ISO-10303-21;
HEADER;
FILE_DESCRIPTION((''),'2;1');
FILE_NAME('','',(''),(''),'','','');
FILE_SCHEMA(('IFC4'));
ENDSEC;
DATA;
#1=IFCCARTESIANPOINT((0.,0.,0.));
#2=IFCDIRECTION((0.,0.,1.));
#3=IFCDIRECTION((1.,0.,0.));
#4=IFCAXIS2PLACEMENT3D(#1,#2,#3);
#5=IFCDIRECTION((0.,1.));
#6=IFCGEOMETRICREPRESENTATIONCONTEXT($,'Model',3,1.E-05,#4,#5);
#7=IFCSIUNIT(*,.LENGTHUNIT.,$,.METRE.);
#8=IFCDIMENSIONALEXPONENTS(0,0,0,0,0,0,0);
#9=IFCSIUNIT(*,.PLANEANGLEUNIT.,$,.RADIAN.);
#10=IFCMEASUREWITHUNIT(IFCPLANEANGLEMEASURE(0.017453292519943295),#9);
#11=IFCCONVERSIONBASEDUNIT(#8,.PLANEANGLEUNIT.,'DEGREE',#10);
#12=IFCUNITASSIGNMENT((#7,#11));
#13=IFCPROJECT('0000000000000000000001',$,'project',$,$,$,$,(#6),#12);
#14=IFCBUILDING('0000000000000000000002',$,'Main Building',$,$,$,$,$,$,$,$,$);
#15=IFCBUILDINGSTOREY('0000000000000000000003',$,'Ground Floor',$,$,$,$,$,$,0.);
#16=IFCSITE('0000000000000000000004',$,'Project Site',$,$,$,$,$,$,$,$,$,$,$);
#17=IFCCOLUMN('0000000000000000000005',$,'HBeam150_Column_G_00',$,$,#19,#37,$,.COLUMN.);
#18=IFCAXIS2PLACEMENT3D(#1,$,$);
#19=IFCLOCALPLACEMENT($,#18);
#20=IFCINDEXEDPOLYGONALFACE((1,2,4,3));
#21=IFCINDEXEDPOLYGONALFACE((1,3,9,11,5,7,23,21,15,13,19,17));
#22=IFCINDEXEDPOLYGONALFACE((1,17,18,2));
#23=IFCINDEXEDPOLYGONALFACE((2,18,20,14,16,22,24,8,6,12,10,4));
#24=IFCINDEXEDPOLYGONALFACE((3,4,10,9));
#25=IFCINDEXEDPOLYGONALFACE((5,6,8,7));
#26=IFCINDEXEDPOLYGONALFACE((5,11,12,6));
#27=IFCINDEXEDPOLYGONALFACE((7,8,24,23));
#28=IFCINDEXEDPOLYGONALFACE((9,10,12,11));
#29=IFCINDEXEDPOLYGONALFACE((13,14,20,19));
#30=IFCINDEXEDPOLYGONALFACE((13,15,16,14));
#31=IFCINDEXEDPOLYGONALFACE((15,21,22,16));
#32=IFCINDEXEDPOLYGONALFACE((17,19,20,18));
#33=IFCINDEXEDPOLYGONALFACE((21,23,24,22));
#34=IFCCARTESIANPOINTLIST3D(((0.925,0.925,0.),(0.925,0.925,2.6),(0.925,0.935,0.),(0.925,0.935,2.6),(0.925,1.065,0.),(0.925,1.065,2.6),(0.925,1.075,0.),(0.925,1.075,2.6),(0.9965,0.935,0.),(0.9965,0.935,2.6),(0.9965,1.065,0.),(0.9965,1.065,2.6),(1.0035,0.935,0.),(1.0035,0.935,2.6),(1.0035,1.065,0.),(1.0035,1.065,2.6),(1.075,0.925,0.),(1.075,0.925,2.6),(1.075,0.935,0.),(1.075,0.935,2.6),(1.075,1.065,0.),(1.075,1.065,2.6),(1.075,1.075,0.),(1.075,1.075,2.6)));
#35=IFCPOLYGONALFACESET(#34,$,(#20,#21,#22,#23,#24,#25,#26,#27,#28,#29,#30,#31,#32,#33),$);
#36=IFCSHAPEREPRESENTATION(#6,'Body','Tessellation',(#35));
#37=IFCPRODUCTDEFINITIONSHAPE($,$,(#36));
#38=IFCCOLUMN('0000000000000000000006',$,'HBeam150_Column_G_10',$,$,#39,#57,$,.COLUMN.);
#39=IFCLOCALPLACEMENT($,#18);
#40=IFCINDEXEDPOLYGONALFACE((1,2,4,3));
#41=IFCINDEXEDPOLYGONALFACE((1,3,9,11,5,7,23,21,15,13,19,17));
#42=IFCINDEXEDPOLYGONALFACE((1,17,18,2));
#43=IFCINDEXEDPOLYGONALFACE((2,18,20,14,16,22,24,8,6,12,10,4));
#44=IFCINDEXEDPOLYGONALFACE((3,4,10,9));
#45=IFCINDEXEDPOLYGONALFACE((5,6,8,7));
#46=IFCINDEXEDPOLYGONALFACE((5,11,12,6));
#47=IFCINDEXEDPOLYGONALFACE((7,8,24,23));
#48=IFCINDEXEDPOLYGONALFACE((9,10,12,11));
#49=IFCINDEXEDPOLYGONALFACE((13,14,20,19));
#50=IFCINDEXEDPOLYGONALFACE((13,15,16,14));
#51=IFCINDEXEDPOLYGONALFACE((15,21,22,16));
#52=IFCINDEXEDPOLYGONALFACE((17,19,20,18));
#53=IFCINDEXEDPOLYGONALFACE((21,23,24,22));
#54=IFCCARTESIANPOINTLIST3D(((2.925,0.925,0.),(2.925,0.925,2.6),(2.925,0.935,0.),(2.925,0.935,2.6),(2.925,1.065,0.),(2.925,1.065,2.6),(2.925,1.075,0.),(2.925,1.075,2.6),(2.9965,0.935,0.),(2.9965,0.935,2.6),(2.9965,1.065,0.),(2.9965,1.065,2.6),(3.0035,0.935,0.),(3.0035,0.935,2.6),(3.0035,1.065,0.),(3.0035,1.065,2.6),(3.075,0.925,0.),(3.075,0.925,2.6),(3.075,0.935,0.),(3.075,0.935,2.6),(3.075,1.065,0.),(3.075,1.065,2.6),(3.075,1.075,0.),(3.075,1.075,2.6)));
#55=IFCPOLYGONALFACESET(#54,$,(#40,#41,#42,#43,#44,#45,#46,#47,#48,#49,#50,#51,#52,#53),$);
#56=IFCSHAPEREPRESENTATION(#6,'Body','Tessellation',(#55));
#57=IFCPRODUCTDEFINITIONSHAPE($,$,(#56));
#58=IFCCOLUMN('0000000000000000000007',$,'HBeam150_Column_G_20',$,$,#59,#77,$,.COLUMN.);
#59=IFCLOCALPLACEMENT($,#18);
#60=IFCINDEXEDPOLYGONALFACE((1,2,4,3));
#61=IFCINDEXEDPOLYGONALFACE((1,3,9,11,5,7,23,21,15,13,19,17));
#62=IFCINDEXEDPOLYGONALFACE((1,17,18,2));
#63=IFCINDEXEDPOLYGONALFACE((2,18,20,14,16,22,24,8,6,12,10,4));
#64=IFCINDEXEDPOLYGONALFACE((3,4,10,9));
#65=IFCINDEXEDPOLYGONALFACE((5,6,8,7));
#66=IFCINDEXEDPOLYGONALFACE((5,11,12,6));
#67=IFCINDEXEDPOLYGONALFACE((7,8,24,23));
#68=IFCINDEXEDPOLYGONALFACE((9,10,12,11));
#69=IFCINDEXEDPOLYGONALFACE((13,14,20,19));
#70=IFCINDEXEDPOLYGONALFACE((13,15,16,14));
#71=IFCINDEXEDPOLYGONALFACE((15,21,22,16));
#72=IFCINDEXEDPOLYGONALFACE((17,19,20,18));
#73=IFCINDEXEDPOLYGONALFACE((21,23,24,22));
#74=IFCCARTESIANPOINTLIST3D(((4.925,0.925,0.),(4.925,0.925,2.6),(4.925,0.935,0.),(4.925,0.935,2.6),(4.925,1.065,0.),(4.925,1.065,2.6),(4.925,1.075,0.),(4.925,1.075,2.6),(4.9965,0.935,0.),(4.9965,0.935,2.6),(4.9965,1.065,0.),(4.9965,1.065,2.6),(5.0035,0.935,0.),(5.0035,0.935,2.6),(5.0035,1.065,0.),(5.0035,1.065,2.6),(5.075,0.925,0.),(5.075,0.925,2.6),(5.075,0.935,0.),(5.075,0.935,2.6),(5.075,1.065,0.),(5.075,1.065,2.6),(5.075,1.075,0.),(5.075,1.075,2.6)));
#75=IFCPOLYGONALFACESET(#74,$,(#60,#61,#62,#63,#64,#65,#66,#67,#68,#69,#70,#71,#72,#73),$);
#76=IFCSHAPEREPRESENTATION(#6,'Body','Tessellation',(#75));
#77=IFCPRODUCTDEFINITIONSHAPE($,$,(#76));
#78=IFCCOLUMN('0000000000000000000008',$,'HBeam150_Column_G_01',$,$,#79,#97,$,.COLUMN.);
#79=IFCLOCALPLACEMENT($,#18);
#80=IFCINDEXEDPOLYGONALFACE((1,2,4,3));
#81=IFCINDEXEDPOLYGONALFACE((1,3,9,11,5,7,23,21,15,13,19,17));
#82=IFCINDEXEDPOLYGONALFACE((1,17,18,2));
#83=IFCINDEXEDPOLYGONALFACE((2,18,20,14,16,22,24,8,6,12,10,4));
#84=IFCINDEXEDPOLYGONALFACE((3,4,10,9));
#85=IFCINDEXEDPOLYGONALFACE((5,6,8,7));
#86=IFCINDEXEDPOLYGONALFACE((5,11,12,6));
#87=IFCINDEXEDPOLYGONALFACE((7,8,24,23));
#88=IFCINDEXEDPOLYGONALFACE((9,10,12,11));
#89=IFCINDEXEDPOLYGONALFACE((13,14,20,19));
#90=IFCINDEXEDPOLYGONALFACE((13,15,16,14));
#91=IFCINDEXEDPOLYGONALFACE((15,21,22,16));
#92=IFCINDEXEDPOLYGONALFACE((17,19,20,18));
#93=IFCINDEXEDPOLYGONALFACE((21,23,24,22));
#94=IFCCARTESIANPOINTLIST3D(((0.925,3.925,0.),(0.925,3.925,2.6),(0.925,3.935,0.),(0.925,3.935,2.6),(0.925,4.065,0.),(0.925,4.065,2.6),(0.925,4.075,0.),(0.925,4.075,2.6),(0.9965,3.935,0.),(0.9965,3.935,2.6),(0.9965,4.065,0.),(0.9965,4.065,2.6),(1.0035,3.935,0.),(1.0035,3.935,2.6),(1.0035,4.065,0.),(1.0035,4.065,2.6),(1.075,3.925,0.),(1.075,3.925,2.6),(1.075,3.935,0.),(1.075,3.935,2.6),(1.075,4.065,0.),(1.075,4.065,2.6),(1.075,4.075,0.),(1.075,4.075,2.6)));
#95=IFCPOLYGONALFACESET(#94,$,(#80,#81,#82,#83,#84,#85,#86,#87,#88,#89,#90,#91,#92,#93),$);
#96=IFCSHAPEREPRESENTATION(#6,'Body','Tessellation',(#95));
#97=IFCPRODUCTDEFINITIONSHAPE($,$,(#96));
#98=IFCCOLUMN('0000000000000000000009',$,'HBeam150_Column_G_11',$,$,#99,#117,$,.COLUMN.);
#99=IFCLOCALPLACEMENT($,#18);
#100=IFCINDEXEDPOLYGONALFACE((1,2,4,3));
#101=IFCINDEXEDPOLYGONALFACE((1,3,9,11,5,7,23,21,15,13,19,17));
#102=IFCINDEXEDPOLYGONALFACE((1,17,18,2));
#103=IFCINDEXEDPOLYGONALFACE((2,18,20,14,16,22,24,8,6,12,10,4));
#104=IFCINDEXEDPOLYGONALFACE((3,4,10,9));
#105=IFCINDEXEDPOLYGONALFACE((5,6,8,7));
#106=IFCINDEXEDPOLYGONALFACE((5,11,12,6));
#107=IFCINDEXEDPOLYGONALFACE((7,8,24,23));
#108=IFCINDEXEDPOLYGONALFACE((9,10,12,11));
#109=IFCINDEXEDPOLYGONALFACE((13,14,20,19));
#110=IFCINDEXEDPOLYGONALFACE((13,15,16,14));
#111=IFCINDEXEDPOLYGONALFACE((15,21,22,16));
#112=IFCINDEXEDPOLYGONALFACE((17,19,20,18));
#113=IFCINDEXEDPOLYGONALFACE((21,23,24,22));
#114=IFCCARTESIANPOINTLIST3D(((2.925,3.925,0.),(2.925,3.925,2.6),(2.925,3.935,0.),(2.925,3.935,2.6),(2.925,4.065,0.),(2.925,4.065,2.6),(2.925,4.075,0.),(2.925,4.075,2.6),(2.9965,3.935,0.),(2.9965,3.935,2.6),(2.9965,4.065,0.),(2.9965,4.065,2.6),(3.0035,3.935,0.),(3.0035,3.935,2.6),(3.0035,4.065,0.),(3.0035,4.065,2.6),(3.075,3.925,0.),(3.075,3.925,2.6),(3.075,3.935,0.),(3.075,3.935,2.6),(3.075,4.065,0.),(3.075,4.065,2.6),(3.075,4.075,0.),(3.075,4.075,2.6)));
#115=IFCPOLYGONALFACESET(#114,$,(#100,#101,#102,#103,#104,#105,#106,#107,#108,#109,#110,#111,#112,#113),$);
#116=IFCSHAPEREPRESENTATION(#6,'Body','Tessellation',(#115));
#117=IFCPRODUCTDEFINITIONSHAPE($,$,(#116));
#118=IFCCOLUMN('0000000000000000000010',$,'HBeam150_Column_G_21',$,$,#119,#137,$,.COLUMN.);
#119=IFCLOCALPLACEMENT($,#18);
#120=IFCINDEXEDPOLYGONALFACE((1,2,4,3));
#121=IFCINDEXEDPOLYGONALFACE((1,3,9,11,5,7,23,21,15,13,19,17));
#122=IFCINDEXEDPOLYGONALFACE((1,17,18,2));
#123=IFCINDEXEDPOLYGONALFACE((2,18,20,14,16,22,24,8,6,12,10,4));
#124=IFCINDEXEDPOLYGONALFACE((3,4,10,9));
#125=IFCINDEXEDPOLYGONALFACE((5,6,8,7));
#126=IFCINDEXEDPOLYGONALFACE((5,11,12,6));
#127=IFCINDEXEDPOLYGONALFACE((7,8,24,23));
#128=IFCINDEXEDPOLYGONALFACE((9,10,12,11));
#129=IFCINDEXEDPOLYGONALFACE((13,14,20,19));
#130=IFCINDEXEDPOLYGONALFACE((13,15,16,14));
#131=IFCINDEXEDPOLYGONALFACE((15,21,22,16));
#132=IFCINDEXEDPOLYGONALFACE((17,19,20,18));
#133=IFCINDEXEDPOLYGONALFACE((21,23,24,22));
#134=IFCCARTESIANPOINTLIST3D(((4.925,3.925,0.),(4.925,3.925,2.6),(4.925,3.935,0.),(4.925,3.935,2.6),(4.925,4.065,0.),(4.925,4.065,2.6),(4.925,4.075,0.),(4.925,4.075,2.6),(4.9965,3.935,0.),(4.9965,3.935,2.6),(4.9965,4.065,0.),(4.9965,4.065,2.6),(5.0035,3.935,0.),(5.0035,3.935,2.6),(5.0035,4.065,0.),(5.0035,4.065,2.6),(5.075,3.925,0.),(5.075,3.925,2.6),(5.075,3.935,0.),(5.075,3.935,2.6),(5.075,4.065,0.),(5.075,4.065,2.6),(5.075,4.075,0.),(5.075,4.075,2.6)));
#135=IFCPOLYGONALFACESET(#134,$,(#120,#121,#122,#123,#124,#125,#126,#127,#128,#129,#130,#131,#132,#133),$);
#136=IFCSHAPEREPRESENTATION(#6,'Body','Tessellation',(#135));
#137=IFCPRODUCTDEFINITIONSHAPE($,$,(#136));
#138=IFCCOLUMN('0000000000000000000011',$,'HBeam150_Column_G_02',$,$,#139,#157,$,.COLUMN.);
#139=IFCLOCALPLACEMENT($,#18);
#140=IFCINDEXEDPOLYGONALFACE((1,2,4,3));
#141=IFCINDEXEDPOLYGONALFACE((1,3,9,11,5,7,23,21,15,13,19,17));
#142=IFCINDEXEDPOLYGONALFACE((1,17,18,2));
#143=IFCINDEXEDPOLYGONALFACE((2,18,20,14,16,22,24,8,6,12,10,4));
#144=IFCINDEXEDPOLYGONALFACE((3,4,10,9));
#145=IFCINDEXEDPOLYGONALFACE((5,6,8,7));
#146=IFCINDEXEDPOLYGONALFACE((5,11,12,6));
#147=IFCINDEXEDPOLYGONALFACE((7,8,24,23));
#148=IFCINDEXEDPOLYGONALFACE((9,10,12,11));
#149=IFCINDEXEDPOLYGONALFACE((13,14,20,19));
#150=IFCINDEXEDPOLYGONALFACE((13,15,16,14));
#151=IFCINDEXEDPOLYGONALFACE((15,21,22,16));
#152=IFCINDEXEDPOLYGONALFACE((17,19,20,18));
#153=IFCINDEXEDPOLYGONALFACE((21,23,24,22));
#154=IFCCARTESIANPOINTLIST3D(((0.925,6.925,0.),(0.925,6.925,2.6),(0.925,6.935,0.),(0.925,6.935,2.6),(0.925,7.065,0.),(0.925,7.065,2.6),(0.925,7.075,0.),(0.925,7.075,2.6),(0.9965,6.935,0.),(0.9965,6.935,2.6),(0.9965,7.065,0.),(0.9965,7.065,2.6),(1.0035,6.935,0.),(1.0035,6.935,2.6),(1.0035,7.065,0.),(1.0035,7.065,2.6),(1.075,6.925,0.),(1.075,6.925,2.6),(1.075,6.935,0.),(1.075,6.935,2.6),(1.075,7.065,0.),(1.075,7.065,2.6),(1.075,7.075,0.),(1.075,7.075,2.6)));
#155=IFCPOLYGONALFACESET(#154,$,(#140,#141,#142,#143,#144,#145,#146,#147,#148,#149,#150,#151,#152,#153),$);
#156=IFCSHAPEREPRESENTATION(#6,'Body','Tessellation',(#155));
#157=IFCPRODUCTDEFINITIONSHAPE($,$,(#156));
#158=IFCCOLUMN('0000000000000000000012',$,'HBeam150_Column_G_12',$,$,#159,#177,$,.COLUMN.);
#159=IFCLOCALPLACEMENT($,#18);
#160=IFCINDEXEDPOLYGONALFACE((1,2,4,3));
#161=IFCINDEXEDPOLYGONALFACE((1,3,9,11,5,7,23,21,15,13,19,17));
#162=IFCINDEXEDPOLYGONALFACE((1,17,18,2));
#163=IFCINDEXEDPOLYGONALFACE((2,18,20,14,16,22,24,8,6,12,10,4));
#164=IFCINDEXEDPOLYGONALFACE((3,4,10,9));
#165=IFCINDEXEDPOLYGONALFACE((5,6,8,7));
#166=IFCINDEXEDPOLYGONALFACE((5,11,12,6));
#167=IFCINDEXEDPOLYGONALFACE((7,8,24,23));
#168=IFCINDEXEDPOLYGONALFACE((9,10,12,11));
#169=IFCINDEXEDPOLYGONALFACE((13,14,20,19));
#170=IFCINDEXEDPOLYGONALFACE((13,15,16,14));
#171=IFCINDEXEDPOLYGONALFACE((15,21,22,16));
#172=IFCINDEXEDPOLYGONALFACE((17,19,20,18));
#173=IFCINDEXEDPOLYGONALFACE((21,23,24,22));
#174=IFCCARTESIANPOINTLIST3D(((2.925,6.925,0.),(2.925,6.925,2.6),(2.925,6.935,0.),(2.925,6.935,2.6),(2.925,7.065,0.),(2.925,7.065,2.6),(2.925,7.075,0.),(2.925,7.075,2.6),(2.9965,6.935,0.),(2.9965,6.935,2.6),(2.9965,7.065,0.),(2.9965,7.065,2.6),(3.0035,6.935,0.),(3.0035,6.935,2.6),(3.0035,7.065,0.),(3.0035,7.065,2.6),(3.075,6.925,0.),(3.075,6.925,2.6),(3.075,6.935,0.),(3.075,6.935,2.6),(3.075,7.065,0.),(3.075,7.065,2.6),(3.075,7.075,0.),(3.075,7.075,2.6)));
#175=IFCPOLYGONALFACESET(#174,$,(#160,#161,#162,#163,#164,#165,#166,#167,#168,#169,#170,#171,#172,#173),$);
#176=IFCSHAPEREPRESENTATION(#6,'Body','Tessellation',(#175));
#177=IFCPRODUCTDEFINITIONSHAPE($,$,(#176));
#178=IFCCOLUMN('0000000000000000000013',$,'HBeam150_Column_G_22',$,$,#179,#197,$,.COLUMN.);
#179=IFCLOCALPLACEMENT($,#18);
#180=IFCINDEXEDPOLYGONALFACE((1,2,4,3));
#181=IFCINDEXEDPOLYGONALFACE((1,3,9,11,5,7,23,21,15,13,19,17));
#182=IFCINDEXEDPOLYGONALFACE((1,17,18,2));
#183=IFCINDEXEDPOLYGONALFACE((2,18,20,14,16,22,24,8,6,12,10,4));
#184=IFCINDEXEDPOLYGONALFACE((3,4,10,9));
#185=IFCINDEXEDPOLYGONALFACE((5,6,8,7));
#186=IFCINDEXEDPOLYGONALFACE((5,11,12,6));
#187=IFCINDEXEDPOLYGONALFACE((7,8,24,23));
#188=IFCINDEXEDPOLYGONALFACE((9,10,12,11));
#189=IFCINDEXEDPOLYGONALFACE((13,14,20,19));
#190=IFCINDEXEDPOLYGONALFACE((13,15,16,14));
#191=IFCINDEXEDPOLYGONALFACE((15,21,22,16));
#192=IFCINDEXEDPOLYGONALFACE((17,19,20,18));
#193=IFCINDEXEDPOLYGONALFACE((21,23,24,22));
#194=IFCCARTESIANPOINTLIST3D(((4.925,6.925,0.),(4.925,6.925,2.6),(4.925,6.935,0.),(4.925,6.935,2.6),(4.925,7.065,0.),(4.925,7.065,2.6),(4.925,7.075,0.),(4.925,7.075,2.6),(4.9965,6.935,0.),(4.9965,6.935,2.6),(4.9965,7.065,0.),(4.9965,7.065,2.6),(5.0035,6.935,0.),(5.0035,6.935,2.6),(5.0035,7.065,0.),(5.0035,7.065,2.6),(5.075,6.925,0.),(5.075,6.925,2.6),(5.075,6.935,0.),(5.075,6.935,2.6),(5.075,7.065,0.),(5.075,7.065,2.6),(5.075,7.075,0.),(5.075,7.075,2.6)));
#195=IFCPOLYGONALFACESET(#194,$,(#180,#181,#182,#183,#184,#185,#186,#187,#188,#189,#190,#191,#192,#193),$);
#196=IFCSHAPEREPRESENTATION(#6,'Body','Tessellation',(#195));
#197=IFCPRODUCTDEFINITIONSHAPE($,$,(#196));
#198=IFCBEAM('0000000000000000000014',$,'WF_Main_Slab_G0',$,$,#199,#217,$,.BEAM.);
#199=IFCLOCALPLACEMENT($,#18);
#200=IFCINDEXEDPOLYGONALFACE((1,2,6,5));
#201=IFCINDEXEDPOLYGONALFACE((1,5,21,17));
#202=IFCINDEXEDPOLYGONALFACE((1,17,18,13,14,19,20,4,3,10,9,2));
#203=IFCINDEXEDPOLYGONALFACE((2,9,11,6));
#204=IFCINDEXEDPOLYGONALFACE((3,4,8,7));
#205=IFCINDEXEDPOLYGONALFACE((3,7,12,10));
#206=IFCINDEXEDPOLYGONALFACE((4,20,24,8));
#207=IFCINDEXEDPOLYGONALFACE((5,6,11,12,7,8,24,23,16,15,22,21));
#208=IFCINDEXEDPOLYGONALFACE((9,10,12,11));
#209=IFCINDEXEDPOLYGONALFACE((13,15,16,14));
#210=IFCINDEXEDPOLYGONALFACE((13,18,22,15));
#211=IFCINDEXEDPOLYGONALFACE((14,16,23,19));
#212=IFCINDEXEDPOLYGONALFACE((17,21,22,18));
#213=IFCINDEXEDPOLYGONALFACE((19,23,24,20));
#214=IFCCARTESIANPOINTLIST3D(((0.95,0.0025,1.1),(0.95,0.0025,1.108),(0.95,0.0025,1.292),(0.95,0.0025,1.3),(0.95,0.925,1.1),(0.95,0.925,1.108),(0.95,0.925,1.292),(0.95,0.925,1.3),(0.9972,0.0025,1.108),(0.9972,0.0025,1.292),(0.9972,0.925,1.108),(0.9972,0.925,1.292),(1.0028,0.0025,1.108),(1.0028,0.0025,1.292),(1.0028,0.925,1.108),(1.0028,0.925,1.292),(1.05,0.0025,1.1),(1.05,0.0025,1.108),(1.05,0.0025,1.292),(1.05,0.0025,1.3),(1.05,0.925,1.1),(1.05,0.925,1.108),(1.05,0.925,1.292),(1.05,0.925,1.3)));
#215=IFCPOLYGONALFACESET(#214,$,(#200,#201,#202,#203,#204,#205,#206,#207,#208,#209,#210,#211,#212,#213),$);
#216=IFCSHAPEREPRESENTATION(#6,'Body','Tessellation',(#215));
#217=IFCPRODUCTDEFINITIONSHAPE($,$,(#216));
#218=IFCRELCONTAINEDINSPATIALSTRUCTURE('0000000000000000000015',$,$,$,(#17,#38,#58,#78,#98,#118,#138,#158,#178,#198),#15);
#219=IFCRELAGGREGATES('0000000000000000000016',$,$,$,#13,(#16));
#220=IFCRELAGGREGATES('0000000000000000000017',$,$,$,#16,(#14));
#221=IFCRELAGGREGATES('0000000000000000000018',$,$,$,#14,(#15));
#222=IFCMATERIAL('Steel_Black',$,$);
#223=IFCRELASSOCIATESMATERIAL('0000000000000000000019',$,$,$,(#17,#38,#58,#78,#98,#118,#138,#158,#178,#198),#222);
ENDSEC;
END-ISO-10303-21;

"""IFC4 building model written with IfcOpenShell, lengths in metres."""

from ifc_helpers import new_model, entity, si_unit, converted_unit, direction, frame, frame_2d, origin, origin_with_axes, origin_2d, place, context, project, spatial, i_section, extrude, material, element, save


model = new_model("IFC4")

# Units and contexts
model_context = context("Model", 3, precision=1e-05, world=origin_with_axes(), true_north=direction((0.0, 1.0)))
ifc_project = project(units=[si_unit("LENGTHUNIT", "METRE"), converted_unit("PLANEANGLEUNIT", "DEGREE", entity("IfcPlaneAngleMeasure", 0.017453292519943295), si_unit("PLANEANGLEUNIT", "RADIAN"), dimensions=[0, 0, 0, 0, 0, 0, 0])], contexts=[model_context])

# Site, building, storey
site = spatial("IfcSite", under=ifc_project, Name="Project Site")
building = spatial("IfcBuilding", under=site, Name="Main Building")
storey = spatial("IfcBuildingStorey", under=building, Name="Ground Floor", Elevation=0.0)

# Columns
ifc_material = material(Name="Steel_Black")
for number, where, z_axis, x_axis, name in (
    (1, (1.0, 1.0, 0.0), (0.0, 0.0, 1.0), (1.0, 0.0, 0.0), "HBeam150_Column_G_00"),
    (2, (3.0, 1.0, 0.0), (0.0, 0.0, 1.0), (1.0, 0.0, 0.0), "HBeam150_Column_G_10"),
    (3, (5.0, 1.0, 0.0), (0.0, 0.0, 1.0), (1.0, 0.0, 0.0), "HBeam150_Column_G_20"),
    (4, (1.0, 4.0, 0.0), (0.0, 0.0, 1.0), (1.0, 0.0, 0.0), "HBeam150_Column_G_01"),
    (5, (3.0, 4.0, 0.0), (0.0, 0.0, 1.0), (1.0, 0.0, 0.0), "HBeam150_Column_G_11"),
    (6, (5.0, 4.0, 0.0), (0.0, 0.0, 1.0), (1.0, 0.0, 0.0), "HBeam150_Column_G_21"),
    (7, (1.0, 7.0, 0.0), (0.0, 0.0, 1.0), (1.0, 0.0, 0.0), "HBeam150_Column_G_02"),
    (8, (3.0, 7.0, 0.0), (0.0, 0.0, 1.0), (1.0, 0.0, 0.0), "HBeam150_Column_G_12"),
    (9, (5.0, 7.0, 0.0), (0.0, 0.0, 1.0), (1.0, 0.0, 0.0), "HBeam150_Column_G_22"),
):
    element("IfcColumn", number, at=place(None, frame(where, z_axis=z_axis, x_axis=x_axis)), inside=storey, material=ifc_material, Name=name, PredefinedType="COLUMN", context=model_context, shape_type="SweptSolid", body=[
        extrude(i_section(OverallWidth=0.15, OverallDepth=0.15, WebThickness=0.007, FlangeThickness=0.01, at=origin_2d()), origin(), (0.0, 0.0, 1.0), 2.6),
    ])

# Beam
beam_1_placement = place(None, frame((1.0, 0.0025, 1.1), z_axis=(0.0, 0.0, 1.0), x_axis=(0.0, 1.0, 0.0)))
element("IfcBeam", 10, at=beam_1_placement, inside=storey, material=ifc_material, Name="WF_Main_Slab_G0", PredefinedType="BEAM", context=model_context, shape_type="SweptSolid", body=[
    extrude(i_section(OverallWidth=0.1, OverallDepth=0.2, WebThickness=0.0055, FlangeThickness=0.008, at=frame_2d((0.0, 0.1))), frame((0.0, 0.0, 0.0), z_axis=(1.0, 0.0, 0.0), x_axis=(0.0, 1.0, 0.0)), (0.0, 0.0, 1.0), 0.9225),
])

save(model, "model.ifc")
